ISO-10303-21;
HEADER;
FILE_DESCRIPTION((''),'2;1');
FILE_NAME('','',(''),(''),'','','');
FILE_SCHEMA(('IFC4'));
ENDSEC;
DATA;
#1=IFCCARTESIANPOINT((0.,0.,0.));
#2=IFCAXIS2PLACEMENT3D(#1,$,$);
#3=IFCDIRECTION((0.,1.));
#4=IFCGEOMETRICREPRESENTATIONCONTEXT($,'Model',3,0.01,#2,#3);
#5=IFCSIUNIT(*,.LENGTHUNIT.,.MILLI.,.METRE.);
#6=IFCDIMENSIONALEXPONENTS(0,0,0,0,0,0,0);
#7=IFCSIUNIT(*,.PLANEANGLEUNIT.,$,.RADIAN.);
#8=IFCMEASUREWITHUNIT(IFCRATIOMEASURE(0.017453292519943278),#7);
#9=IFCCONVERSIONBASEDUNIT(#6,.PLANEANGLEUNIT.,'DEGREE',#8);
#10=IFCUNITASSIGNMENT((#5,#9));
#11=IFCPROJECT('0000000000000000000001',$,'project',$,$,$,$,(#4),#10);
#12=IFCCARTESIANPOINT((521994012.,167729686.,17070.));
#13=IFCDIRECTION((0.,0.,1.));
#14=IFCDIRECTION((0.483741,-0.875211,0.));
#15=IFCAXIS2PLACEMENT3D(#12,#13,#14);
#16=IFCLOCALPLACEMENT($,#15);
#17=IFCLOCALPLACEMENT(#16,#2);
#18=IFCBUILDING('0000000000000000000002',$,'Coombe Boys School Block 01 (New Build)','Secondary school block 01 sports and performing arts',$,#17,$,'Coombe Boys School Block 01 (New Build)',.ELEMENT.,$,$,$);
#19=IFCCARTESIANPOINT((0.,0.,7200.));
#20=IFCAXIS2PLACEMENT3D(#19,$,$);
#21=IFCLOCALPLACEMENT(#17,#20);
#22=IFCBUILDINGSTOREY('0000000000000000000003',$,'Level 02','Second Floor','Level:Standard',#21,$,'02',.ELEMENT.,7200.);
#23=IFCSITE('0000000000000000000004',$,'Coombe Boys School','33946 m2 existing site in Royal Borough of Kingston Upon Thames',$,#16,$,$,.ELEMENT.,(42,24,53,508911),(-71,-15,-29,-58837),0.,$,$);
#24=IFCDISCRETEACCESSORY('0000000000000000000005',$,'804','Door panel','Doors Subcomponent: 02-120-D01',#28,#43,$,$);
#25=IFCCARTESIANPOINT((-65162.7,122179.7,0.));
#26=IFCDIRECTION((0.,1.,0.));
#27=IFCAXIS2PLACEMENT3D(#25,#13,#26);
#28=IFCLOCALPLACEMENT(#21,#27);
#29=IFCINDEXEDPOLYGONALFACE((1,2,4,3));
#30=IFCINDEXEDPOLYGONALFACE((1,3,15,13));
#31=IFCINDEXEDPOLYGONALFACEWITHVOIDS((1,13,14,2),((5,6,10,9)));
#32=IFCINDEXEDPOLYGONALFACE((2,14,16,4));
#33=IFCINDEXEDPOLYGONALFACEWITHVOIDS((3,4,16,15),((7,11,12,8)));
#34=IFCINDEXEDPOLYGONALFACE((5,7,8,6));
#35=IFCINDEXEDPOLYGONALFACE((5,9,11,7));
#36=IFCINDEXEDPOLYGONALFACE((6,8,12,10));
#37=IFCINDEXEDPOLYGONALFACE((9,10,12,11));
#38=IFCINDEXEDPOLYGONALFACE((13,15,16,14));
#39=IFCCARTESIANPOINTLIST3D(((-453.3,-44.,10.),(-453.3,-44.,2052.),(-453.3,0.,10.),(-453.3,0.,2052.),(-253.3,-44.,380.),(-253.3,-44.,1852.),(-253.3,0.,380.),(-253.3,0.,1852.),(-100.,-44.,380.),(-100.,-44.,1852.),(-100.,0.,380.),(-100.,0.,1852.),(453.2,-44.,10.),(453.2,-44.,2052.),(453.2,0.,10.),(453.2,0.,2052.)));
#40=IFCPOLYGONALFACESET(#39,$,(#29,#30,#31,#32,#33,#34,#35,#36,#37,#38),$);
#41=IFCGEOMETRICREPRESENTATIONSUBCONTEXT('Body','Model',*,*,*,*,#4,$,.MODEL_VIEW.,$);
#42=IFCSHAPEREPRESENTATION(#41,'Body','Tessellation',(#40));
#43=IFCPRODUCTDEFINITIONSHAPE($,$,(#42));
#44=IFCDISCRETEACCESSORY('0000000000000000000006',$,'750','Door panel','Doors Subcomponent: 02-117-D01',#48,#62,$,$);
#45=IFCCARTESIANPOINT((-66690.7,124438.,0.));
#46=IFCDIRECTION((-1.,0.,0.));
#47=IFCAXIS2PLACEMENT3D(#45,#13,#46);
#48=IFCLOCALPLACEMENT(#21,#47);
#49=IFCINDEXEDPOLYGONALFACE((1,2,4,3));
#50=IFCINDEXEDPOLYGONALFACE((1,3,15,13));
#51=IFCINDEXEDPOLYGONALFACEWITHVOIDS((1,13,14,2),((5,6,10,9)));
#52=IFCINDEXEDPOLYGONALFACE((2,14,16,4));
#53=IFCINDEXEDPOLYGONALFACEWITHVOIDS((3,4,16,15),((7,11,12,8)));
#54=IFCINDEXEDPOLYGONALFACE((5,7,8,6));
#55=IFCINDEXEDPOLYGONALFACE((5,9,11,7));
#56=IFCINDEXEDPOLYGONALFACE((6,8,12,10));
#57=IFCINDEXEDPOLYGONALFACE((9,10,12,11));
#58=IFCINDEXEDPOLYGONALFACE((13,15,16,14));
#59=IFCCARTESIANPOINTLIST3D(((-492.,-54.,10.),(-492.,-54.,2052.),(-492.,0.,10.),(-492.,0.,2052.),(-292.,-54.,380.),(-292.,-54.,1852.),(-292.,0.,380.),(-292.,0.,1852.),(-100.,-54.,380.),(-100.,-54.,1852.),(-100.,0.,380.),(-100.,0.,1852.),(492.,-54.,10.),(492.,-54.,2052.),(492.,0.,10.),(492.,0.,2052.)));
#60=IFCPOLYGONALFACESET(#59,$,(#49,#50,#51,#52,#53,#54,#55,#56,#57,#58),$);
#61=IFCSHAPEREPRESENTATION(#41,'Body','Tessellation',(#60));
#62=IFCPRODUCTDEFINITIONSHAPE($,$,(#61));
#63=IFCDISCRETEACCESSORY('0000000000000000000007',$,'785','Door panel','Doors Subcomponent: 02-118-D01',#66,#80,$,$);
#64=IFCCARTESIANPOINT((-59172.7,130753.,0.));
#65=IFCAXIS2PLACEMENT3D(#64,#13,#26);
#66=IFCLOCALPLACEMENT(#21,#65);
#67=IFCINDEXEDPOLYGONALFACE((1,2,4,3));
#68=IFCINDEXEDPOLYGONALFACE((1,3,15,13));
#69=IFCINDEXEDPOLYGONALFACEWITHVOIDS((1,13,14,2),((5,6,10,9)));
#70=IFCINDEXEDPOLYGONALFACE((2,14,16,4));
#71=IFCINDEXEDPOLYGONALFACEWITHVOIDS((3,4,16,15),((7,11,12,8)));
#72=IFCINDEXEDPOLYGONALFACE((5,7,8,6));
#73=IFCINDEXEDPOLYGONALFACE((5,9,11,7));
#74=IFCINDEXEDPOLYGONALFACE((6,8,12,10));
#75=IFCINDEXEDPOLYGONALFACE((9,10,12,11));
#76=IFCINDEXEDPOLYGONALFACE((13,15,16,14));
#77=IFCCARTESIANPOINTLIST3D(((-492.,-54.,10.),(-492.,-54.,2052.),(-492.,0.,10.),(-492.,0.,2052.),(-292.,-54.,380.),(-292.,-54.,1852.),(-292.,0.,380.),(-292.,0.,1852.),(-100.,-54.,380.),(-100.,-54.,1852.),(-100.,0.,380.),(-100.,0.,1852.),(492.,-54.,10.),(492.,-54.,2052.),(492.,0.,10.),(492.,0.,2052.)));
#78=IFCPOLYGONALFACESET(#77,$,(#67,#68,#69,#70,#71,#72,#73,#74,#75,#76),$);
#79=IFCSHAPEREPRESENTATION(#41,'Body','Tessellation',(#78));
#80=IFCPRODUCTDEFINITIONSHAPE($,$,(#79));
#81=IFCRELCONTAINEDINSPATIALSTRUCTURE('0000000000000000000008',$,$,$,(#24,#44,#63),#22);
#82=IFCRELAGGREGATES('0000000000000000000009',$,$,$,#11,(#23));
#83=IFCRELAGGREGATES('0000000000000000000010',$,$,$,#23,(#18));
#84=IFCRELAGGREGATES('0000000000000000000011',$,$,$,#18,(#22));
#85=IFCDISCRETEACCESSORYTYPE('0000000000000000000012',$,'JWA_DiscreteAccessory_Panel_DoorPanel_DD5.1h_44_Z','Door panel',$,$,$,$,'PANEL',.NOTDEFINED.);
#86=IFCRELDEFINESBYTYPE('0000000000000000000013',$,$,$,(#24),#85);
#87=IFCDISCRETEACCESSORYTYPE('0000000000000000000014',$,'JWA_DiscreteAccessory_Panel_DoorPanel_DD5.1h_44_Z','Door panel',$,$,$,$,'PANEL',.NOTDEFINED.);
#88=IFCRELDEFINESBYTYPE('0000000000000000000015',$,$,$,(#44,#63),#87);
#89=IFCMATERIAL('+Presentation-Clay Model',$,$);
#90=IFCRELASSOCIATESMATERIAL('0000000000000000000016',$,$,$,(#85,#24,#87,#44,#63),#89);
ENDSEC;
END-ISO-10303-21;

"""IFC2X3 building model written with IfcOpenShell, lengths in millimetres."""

from ifc_helpers import new_model, entity, si_unit, converted_unit, direction, frame, origin, place, context, subcontext, project, spatial, polyline, outline, extrude, source, transform, mapped, material, type_object, type_shapes, element, save


model = new_model("IFC2X3")

# Units and contexts
model_context = context("Model", 3, precision=0.01, world=origin(), true_north=direction((0.0, 1.0)))
body_context = subcontext(model_context, "Body", "Model", "MODEL_VIEW")
ifc_project = project(units=[si_unit("LENGTHUNIT", "METRE", prefix="MILLI"), converted_unit("PLANEANGLEUNIT", "DEGREE", entity("IfcRatioMeasure", 0.017453292519943278), si_unit("PLANEANGLEUNIT", "RADIAN"), dimensions=[0, 0, 0, 0, 0, 0, 0])], contexts=[model_context])

# Site, building, storey
site_placement = place(None, frame((521994012.0, 167729686.0, 17070.0), z_axis=(0.0, 0.0, 1.0), x_axis=(0.483741, -0.875211, 0.0)))
site = spatial("IfcSite", under=ifc_project, at=site_placement, Name="Coombe Boys School", Description="33946 m2 existing site in Royal Borough of Kingston Upon Thames", CompositionType="ELEMENT", RefLatitude=(42, 24, 53, 508911), RefLongitude=(-71, -15, -29, -58837), RefElevation=0.0)
building_placement = place(site_placement, origin())
building = spatial("IfcBuilding", under=site, at=building_placement, Name="Coombe Boys School Block 01 (New Build)", Description="Secondary school block 01 sports and performing arts", LongName="Coombe Boys School Block 01 (New Build)", CompositionType="ELEMENT")
storey_placement = place(building_placement, frame((0.0, 0.0, 7200.0)))
storey = spatial("IfcBuildingStorey", under=building, at=storey_placement, Name="Level 02", Description="Second Floor", ObjectType="Level:Standard", LongName="02", CompositionType="ELEMENT", Elevation=7200.0)

# Shared definitions
ifc_material_1 = material(Name="+Presentation-Clay Model")

# Discrete accessory
discrete_accessory_type_1 = type_object("IfcDiscreteAccessoryType", Name="JWA_DiscreteAccessory_Panel_DoorPanel_DD5.1h_44_Z", Description="Door panel", ElementType="PANEL", material=ifc_material_1)
shared_shape_1 = source(origin(), body_context, "Body", "SweptSolid", [
    extrude(outline(polyline([(-1021.0, -453.3), (1021.0, -453.3), (1021.0, 453.3), (-1021.0, 453.3), (-1021.0, -453.3)]), holes=[polyline([(-821.0, 100.0), (-821.0, 253.2), (651.0, 253.2), (651.0, 100.0), (-821.0, 100.0)])]), frame((0.0, -44.0, 1031.0), z_axis=(0.0, 1.0, 0.0), x_axis=(0.0, 0.0, -1.0)), (0.0, 0.0, 1.0), 44.0),
])
type_shapes(discrete_accessory_type_1, [shared_shape_1])
discrete_accessory_1_placement = place(storey_placement, frame((-65162.7, 122179.7, 0.0), z_axis=(0.0, 0.0, 1.0), x_axis=(0.0, 1.0, 0.0)))
element("IfcDiscreteAccessory", 1, at=discrete_accessory_1_placement, inside=storey, type_object=discrete_accessory_type_1, material=ifc_material_1, Name="804", Description="Door panel", ObjectType="Doors Subcomponent: 02-120-D01", context=body_context, shape_type="MappedRepresentation", body=[
    mapped(shared_shape_1, transform((0.0, 0.0, 0.0), scale=1.0)),
])

# Discrete accessories
discrete_accessory_type_2 = type_object("IfcDiscreteAccessoryType", Name="JWA_DiscreteAccessory_Panel_DoorPanel_DD5.1h_44_Z", Description="Door panel", ElementType="PANEL", material=ifc_material_1)
shared_shape_2 = source(origin(), body_context, "Body", "SweptSolid", [
    extrude(outline(polyline([(-1021.0, -492.0), (1021.0, -492.0), (1021.0, 492.0), (-1021.0, 492.0), (-1021.0, -492.0)]), holes=[polyline([(-821.0, 100.0), (-821.0, 292.0), (651.0, 292.0), (651.0, 100.0), (-821.0, 100.0)])]), frame((0.0, -54.0, 1031.0), z_axis=(0.0, 1.0, 0.0), x_axis=(0.0, 0.0, -1.0)), (0.0, 0.0, 1.0), 54.0),
])
type_shapes(discrete_accessory_type_2, [shared_shape_2])
discrete_accessory_2_placement = place(storey_placement, frame((-66690.7, 124438.0, 0.0), z_axis=(0.0, 0.0, 1.0), x_axis=(-1.0, 0.0, 0.0)))
element("IfcDiscreteAccessory", 2, at=discrete_accessory_2_placement, inside=storey, type_object=discrete_accessory_type_2, material=ifc_material_1, Name="750", Description="Door panel", ObjectType="Doors Subcomponent: 02-117-D01", context=body_context, shape_type="MappedRepresentation", body=[
    mapped(shared_shape_2, transform((0.0, 0.0, 0.0), scale=1.0)),
])
discrete_accessory_3_placement = place(storey_placement, frame((-59172.7, 130753.0, 0.0), z_axis=(0.0, 0.0, 1.0), x_axis=(0.0, 1.0, 0.0)))
element("IfcDiscreteAccessory", 3, at=discrete_accessory_3_placement, inside=storey, type_object=discrete_accessory_type_2, material=ifc_material_1, Name="785", Description="Door panel", ObjectType="Doors Subcomponent: 02-118-D01", context=body_context, shape_type="MappedRepresentation", body=[
    mapped(shared_shape_2, transform((0.0, 0.0, 0.0), scale=1.0)),
])

save(model, "model.ifc")
